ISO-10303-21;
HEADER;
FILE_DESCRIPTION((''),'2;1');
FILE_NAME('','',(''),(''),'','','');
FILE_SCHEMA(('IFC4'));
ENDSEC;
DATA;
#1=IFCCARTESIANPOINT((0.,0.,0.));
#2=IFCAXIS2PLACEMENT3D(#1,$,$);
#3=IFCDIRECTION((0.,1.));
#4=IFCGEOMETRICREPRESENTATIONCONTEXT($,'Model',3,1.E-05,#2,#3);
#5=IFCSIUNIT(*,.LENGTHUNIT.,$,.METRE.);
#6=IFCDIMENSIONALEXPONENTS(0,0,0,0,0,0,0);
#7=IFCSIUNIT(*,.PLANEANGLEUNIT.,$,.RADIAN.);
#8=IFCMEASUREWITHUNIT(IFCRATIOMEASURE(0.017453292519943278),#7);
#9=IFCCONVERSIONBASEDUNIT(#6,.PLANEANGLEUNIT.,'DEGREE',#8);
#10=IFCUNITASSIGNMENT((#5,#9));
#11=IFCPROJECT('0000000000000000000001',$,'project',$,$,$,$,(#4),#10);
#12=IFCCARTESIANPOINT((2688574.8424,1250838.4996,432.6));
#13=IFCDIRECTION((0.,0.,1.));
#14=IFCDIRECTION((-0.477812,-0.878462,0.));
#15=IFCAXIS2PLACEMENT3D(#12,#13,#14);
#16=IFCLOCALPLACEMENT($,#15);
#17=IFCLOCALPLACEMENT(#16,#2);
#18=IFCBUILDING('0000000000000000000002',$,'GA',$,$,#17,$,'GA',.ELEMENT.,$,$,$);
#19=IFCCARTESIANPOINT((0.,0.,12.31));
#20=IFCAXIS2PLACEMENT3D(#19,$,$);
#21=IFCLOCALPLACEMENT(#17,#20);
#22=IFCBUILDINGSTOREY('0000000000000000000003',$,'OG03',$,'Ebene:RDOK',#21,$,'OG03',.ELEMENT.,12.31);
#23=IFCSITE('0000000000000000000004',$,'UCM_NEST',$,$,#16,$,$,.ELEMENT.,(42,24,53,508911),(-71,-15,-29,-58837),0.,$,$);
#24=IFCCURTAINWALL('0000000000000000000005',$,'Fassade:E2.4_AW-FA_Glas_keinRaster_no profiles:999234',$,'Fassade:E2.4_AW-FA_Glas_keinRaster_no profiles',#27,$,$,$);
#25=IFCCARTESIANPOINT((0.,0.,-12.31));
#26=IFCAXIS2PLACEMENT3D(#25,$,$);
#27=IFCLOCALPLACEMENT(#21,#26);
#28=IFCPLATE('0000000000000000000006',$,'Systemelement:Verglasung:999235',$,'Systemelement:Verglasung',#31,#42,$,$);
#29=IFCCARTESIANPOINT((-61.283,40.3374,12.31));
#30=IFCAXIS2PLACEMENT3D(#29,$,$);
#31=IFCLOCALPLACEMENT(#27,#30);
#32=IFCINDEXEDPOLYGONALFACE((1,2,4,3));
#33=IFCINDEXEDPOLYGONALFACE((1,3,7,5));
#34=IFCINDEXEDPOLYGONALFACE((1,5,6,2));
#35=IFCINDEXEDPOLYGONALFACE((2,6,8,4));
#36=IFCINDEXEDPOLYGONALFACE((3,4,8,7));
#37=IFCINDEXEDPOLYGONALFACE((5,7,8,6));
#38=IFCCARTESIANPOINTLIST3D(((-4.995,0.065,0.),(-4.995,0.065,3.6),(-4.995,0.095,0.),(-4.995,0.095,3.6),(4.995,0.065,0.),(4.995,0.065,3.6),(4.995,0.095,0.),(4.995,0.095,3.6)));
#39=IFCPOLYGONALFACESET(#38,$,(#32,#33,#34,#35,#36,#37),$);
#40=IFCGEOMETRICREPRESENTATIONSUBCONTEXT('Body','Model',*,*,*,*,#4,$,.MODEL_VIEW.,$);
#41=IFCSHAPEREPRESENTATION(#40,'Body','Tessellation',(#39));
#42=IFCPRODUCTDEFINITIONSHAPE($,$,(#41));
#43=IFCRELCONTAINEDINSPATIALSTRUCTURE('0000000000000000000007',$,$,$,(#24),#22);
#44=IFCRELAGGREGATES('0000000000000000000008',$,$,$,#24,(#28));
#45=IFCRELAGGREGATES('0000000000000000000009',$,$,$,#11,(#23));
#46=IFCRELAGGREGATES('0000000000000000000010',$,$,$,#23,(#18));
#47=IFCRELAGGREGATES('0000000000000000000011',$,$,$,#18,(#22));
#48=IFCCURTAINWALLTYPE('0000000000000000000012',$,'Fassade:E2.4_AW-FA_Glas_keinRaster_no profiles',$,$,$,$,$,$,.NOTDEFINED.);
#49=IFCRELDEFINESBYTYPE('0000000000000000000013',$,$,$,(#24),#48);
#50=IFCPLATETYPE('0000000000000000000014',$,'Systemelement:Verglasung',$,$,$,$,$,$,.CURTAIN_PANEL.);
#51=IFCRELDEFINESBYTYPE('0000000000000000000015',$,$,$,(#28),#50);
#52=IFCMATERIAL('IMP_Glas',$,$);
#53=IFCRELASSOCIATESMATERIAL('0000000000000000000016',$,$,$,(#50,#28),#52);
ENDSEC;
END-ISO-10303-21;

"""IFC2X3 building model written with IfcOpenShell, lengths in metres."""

from ifc_helpers import new_model, entity, si_unit, converted_unit, direction, frame, frame_2d, origin, place, context, subcontext, project, spatial, rectangle, extrude, source, transform, mapped, material, type_object, type_shapes, element, aggregate, save


model = new_model("IFC2X3")

# Units and contexts
model_context = context("Model", 3, precision=1e-05, world=origin(), true_north=direction((0.0, 1.0)))
body_context = subcontext(model_context, "Body", "Model", "MODEL_VIEW")
ifc_project = project(units=[si_unit("LENGTHUNIT", "METRE"), converted_unit("PLANEANGLEUNIT", "DEGREE", entity("IfcRatioMeasure", 0.017453292519943278), si_unit("PLANEANGLEUNIT", "RADIAN"), dimensions=[0, 0, 0, 0, 0, 0, 0])], contexts=[model_context])

# Site, building, storey
site_placement = place(None, frame((2688574.8424, 1250838.4996, 432.6), z_axis=(0.0, 0.0, 1.0), x_axis=(-0.477812, -0.878462, 0.0)))
site = spatial("IfcSite", under=ifc_project, at=site_placement, Name="UCM_NEST", CompositionType="ELEMENT", RefLatitude=(42, 24, 53, 508911), RefLongitude=(-71, -15, -29, -58837), RefElevation=0.0)
building_placement = place(site_placement, origin())
building = spatial("IfcBuilding", under=site, at=building_placement, Name="GA", LongName="GA", CompositionType="ELEMENT")
storey_placement = place(building_placement, frame((0.0, 0.0, 12.31)))
storey = spatial("IfcBuildingStorey", under=building, at=storey_placement, Name="OG03", ObjectType="Ebene:RDOK", LongName="OG03", CompositionType="ELEMENT", Elevation=12.31)

# Curtain wall, plate
curtain_wall_type = type_object("IfcCurtainWallType", Name="Fassade:E2.4_AW-FA_Glas_keinRaster_no profiles", PredefinedType="NOTDEFINED")
curtain_wall_placement = place(storey_placement, frame((0.0, 0.0, -12.31)))
curtain_wall = element("IfcCurtainWall", 1, at=curtain_wall_placement, inside=storey, type_object=curtain_wall_type, Name="Fassade:E2.4_AW-FA_Glas_keinRaster_no profiles:999234", ObjectType="Fassade:E2.4_AW-FA_Glas_keinRaster_no profiles")
ifc_material_1 = material(Name="IMP_Glas")
plate_type = type_object("IfcPlateType", Name="Systemelement:Verglasung", PredefinedType="CURTAIN_PANEL", material=ifc_material_1)
shared_shape_1 = source(origin(), body_context, "Body", "SweptSolid", [
    extrude(rectangle(XDim=0.03, YDim=9.99, at=frame_2d((0.0, 0.0), x_axis=(1.0, 0.0))), frame((0.0, 0.08, 0.0), z_axis=(0.0, 0.0, 1.0), x_axis=(0.0, 1.0, 0.0)), (0.0, 0.0, 1.0), 3.6),
])
type_shapes(plate_type, [shared_shape_1])
plate_placement = place(curtain_wall_placement, frame((-61.283, 40.3374, 12.31)))
plate = element("IfcPlate", 2, at=plate_placement, type_object=plate_type, material=ifc_material_1, Name="Systemelement:Verglasung:999235", ObjectType="Systemelement:Verglasung", context=body_context, shape_type="MappedRepresentation", body=[
    mapped(shared_shape_1, transform((0.0, 0.0, 0.0), scale=1.0)),
])
aggregate(curtain_wall, [plate])

save(model, "model.ifc")
